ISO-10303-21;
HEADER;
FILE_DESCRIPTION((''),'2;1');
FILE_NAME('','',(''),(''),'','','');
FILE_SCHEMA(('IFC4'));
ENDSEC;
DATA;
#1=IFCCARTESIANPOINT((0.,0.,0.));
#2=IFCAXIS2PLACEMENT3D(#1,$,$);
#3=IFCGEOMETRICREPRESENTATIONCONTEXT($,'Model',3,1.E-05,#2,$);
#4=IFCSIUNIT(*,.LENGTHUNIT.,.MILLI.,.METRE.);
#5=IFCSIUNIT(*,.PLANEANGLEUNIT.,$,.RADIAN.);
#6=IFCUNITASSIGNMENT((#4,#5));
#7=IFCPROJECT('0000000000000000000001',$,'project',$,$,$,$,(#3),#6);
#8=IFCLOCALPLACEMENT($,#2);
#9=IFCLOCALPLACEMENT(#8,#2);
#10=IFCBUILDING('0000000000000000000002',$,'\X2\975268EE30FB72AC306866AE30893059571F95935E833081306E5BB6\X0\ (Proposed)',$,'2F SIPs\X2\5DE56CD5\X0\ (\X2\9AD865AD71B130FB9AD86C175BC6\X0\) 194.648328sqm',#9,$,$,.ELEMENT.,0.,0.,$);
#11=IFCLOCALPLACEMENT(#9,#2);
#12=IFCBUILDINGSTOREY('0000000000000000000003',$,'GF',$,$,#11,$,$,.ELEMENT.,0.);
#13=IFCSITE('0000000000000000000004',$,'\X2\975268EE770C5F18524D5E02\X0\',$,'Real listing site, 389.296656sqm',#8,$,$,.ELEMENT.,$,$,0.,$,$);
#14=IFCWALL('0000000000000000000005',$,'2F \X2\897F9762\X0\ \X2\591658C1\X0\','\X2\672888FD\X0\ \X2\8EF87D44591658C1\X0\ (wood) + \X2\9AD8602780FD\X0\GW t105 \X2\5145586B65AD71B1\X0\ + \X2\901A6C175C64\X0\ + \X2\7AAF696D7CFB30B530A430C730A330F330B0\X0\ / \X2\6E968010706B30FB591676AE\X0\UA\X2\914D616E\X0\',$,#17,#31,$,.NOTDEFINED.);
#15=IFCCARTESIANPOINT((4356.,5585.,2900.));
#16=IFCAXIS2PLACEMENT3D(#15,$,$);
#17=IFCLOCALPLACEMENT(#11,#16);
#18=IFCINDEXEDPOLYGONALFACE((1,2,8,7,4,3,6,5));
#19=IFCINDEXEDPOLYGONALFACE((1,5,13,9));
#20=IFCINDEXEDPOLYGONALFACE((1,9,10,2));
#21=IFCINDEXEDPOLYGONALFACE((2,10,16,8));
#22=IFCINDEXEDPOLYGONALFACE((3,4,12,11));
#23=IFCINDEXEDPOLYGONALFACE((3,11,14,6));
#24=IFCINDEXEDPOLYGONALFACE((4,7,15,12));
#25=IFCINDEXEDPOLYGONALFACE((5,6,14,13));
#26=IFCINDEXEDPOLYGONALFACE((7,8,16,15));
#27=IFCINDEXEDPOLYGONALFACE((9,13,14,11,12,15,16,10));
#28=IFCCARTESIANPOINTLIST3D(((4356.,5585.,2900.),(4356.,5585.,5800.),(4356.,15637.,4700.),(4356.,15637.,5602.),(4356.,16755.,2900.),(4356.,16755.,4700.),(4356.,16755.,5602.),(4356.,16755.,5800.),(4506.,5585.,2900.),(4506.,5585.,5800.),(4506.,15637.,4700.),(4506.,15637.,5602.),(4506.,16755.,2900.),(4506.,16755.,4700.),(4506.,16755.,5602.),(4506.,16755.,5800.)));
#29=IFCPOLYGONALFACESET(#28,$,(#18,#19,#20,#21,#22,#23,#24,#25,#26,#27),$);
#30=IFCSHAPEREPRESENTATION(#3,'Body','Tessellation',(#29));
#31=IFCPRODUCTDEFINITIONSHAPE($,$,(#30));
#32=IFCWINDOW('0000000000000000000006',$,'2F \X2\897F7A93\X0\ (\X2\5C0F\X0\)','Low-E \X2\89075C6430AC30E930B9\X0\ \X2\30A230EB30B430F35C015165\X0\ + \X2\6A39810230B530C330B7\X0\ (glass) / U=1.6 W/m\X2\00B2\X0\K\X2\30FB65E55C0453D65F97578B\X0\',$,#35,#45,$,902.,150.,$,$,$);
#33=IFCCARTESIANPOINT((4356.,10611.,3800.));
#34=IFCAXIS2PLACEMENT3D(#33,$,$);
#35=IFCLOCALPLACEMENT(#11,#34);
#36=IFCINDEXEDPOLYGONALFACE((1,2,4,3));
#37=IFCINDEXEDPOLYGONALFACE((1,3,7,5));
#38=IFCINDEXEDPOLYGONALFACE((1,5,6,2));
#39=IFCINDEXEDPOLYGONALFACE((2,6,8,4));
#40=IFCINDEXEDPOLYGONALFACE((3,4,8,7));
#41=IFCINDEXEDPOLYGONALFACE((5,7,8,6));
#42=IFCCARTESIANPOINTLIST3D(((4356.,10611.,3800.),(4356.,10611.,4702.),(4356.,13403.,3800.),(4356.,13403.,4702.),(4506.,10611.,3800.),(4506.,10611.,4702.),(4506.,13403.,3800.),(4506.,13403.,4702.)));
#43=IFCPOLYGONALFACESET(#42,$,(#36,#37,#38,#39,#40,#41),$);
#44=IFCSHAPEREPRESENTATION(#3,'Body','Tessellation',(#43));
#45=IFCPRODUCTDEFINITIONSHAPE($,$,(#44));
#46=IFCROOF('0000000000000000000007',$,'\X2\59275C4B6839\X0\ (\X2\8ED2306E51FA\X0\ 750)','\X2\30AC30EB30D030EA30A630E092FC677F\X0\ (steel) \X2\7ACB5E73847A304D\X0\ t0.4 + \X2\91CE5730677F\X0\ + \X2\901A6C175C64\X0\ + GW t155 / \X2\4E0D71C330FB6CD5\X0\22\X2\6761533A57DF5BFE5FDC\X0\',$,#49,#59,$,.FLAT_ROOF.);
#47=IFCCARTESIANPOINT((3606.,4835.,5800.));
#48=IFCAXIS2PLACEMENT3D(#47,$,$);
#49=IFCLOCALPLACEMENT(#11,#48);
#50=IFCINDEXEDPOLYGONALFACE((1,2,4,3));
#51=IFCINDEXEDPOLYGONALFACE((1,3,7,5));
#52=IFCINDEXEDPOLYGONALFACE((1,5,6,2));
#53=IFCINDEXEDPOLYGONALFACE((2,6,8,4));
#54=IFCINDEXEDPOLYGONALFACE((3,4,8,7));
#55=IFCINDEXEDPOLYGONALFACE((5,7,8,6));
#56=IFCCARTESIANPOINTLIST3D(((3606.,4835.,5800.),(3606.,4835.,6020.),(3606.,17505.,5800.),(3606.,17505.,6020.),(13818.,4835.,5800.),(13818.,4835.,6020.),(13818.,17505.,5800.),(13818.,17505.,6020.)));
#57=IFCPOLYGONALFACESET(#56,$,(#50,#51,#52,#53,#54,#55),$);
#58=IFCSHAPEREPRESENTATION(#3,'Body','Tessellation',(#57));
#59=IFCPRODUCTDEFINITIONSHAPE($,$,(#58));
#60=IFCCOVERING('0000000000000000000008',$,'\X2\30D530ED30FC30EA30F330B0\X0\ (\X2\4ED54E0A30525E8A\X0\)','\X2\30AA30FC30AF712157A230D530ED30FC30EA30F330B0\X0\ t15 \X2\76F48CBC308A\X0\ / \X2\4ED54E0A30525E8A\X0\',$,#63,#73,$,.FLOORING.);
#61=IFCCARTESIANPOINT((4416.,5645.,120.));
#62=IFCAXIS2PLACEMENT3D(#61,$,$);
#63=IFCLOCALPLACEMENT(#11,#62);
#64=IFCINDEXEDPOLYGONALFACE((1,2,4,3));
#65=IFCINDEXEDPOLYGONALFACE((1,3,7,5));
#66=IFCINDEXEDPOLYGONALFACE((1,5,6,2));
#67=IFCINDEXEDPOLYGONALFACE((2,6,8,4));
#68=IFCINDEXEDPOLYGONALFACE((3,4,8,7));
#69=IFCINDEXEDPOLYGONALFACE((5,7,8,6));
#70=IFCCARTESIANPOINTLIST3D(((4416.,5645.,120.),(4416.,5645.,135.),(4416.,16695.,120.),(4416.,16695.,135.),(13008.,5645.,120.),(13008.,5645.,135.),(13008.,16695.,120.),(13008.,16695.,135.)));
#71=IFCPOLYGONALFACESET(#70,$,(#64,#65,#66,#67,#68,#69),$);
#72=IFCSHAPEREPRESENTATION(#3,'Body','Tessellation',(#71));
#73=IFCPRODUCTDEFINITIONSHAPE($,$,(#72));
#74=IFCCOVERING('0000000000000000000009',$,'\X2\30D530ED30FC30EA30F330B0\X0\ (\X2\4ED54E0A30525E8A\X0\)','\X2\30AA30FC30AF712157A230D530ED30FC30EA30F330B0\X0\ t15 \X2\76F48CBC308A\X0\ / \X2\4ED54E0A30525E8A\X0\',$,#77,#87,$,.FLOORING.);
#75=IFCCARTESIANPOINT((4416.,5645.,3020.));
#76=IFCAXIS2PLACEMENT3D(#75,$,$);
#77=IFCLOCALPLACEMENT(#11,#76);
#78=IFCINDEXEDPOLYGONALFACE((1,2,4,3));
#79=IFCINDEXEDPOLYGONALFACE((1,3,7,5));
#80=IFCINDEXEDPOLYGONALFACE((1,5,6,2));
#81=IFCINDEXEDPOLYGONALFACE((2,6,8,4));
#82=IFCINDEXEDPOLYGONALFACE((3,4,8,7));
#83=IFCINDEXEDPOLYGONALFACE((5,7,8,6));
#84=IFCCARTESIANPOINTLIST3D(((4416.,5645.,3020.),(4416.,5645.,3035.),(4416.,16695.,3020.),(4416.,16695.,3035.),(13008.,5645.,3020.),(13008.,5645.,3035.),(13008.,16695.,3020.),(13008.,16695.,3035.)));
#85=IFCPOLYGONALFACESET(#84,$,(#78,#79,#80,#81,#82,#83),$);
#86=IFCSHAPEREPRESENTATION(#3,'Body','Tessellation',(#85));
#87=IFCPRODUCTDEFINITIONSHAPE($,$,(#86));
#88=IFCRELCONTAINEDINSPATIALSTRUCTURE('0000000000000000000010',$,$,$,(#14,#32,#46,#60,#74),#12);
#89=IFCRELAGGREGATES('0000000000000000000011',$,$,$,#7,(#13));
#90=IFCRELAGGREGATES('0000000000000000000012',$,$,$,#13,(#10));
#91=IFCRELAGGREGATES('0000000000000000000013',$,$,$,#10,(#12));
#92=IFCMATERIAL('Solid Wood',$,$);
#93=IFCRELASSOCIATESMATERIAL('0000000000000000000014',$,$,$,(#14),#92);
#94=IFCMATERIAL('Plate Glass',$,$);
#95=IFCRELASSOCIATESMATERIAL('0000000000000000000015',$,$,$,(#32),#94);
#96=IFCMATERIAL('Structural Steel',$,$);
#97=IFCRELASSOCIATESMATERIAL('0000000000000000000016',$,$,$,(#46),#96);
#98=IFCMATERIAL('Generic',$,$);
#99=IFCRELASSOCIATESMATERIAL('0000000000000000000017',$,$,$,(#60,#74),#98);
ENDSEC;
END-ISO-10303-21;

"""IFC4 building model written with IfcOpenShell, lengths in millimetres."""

from ifc_helpers import new_model, si_unit, frame, frame_2d, origin, place, context, project, spatial, rectangle, extrude, material, element, fill, save


model = new_model("IFC4")

# Units and contexts
model_context = context("Model", 3, precision=1e-05, world=origin())
ifc_project = project(units=[si_unit("LENGTHUNIT", "METRE", prefix="MILLI"), si_unit("PLANEANGLEUNIT", "RADIAN")], contexts=[model_context])

# Site, building, storey
site_placement = place(None, origin())
site = spatial("IfcSite", under=ifc_project, at=site_placement, Name="青森県弘前市", ObjectType="Real listing site, 389.296656sqm", CompositionType="ELEMENT", RefElevation=0.0)
building_placement = place(site_placement, origin())
building = spatial("IfcBuilding", under=site, at=building_placement, Name="青森・犬と暮らす土間広めの家 (Proposed)", ObjectType="2F SIPs工法 (高断熱・高気密) 194.648328sqm", CompositionType="ELEMENT", ElevationOfRefHeight=0.0, ElevationOfTerrain=0.0)
storey_placement = place(building_placement, origin())
storey = spatial("IfcBuildingStorey", under=building, at=storey_placement, Name="GF", CompositionType="ELEMENT", Elevation=0.0)

# Shared definitions
ifc_material_1 = material(Name="Solid Wood")

# Shared definitions
ifc_material_2 = material(Name="Plate Glass")

# Wall, opening, window
wall_1_placement = place(storey_placement, frame((4356.0, 5585.0, 2900.0)))
wall_1 = element("IfcWall", 1, at=wall_1_placement, inside=storey, material=ifc_material_1, Name="2F 西面 外壁", Description="木製 軸組外壁 (wood) + 高性能GW t105 充填断熱 + 通気層 + 窯業系サイディング / 準耐火・外皮UA配慮", PredefinedType="NOTDEFINED", context=model_context, shape_type="SweptSolid", body=[
    extrude(rectangle(XDim=150.0, YDim=11170.0, at=frame_2d((75.0, 5585.0))), frame((4356.0, 5585.0, 2900.0)), (0.0, 0.0, 1.0), 2900.0),
])
opening_1_placement = place(storey_placement, frame((4356.0, 10611.0, 3800.0)))
opening_1 = element("IfcOpeningElement", 2, at=opening_1_placement, cuts=wall_1, PredefinedType="NOTDEFINED", context=model_context, shape_type="SweptSolid", body=[
    extrude(rectangle(XDim=150.0, YDim=2792.0, at=frame_2d((75.0, 1396.0))), frame((4356.0, 10611.0, 3800.0)), (0.0, 0.0, 1.0), 902.0),
])
window_1_placement = place(storey_placement, frame((4356.0, 10611.0, 3800.0)))
window_1 = element("IfcWindow", 3, at=window_1_placement, inside=storey, material=ifc_material_2, Name="2F 西窓 (小)", Description="Low-E 複層ガラス アルゴン封入 + 樹脂サッシ (glass) / U=1.6 W/m²K・日射取得型", OverallHeight=902.0, OverallWidth=150.0, context=model_context, shape_type="SweptSolid", body=[
    extrude(rectangle(XDim=150.0, YDim=2792.0, at=frame_2d((75.0, 1396.0))), frame((4356.0, 10611.0, 3800.0)), (0.0, 0.0, 1.0), 902.0),
])
fill(opening_1, window_1)

# Roof
ifc_material_3 = material(Name="Structural Steel")
roof_placement = place(storey_placement, frame((3606.0, 4835.0, 5800.0)))
element("IfcRoof", 4, at=roof_placement, inside=storey, material=ifc_material_3, Name="大屋根 (軒の出 750)", Description="ガルバリウム鋼板 (steel) 立平葺き t0.4 + 野地板 + 通気層 + GW t155 / 不燃・法22条区域対応", PredefinedType="FLAT_ROOF", context=model_context, shape_type="SweptSolid", body=[
    extrude(rectangle(XDim=10212.0, YDim=12670.0, at=frame_2d((5106.0, 6335.0))), frame((3606.0, 4835.0, 5800.0)), (0.0, 0.0, 1.0), 220.0),
])

# Coverings
ifc_material_4 = material(Name="Generic")
covering_1_placement = place(storey_placement, frame((4416.0, 5645.0, 120.0)))
element("IfcCovering", 5, at=covering_1_placement, inside=storey, material=ifc_material_4, Name="フローリング (仕上げ床)", Description="オーク無垢フローリング t15 直貼り / 仕上げ床", PredefinedType="FLOORING", context=model_context, shape_type="SweptSolid", body=[
    extrude(rectangle(XDim=8592.0, YDim=11050.0, at=frame_2d((4296.0, 5525.0))), frame((4416.0, 5645.0, 120.0)), (0.0, 0.0, 1.0), 15.0),
])
covering_2_placement = place(storey_placement, frame((4416.0, 5645.0, 3020.0)))
element("IfcCovering", 6, at=covering_2_placement, inside=storey, material=ifc_material_4, Name="フローリング (仕上げ床)", Description="オーク無垢フローリング t15 直貼り / 仕上げ床", PredefinedType="FLOORING", context=model_context, shape_type="SweptSolid", body=[
    extrude(rectangle(XDim=8592.0, YDim=11050.0, at=frame_2d((4296.0, 5525.0))), frame((4416.0, 5645.0, 3020.0)), (0.0, 0.0, 1.0), 15.0),
])

save(model, "model.ifc")
